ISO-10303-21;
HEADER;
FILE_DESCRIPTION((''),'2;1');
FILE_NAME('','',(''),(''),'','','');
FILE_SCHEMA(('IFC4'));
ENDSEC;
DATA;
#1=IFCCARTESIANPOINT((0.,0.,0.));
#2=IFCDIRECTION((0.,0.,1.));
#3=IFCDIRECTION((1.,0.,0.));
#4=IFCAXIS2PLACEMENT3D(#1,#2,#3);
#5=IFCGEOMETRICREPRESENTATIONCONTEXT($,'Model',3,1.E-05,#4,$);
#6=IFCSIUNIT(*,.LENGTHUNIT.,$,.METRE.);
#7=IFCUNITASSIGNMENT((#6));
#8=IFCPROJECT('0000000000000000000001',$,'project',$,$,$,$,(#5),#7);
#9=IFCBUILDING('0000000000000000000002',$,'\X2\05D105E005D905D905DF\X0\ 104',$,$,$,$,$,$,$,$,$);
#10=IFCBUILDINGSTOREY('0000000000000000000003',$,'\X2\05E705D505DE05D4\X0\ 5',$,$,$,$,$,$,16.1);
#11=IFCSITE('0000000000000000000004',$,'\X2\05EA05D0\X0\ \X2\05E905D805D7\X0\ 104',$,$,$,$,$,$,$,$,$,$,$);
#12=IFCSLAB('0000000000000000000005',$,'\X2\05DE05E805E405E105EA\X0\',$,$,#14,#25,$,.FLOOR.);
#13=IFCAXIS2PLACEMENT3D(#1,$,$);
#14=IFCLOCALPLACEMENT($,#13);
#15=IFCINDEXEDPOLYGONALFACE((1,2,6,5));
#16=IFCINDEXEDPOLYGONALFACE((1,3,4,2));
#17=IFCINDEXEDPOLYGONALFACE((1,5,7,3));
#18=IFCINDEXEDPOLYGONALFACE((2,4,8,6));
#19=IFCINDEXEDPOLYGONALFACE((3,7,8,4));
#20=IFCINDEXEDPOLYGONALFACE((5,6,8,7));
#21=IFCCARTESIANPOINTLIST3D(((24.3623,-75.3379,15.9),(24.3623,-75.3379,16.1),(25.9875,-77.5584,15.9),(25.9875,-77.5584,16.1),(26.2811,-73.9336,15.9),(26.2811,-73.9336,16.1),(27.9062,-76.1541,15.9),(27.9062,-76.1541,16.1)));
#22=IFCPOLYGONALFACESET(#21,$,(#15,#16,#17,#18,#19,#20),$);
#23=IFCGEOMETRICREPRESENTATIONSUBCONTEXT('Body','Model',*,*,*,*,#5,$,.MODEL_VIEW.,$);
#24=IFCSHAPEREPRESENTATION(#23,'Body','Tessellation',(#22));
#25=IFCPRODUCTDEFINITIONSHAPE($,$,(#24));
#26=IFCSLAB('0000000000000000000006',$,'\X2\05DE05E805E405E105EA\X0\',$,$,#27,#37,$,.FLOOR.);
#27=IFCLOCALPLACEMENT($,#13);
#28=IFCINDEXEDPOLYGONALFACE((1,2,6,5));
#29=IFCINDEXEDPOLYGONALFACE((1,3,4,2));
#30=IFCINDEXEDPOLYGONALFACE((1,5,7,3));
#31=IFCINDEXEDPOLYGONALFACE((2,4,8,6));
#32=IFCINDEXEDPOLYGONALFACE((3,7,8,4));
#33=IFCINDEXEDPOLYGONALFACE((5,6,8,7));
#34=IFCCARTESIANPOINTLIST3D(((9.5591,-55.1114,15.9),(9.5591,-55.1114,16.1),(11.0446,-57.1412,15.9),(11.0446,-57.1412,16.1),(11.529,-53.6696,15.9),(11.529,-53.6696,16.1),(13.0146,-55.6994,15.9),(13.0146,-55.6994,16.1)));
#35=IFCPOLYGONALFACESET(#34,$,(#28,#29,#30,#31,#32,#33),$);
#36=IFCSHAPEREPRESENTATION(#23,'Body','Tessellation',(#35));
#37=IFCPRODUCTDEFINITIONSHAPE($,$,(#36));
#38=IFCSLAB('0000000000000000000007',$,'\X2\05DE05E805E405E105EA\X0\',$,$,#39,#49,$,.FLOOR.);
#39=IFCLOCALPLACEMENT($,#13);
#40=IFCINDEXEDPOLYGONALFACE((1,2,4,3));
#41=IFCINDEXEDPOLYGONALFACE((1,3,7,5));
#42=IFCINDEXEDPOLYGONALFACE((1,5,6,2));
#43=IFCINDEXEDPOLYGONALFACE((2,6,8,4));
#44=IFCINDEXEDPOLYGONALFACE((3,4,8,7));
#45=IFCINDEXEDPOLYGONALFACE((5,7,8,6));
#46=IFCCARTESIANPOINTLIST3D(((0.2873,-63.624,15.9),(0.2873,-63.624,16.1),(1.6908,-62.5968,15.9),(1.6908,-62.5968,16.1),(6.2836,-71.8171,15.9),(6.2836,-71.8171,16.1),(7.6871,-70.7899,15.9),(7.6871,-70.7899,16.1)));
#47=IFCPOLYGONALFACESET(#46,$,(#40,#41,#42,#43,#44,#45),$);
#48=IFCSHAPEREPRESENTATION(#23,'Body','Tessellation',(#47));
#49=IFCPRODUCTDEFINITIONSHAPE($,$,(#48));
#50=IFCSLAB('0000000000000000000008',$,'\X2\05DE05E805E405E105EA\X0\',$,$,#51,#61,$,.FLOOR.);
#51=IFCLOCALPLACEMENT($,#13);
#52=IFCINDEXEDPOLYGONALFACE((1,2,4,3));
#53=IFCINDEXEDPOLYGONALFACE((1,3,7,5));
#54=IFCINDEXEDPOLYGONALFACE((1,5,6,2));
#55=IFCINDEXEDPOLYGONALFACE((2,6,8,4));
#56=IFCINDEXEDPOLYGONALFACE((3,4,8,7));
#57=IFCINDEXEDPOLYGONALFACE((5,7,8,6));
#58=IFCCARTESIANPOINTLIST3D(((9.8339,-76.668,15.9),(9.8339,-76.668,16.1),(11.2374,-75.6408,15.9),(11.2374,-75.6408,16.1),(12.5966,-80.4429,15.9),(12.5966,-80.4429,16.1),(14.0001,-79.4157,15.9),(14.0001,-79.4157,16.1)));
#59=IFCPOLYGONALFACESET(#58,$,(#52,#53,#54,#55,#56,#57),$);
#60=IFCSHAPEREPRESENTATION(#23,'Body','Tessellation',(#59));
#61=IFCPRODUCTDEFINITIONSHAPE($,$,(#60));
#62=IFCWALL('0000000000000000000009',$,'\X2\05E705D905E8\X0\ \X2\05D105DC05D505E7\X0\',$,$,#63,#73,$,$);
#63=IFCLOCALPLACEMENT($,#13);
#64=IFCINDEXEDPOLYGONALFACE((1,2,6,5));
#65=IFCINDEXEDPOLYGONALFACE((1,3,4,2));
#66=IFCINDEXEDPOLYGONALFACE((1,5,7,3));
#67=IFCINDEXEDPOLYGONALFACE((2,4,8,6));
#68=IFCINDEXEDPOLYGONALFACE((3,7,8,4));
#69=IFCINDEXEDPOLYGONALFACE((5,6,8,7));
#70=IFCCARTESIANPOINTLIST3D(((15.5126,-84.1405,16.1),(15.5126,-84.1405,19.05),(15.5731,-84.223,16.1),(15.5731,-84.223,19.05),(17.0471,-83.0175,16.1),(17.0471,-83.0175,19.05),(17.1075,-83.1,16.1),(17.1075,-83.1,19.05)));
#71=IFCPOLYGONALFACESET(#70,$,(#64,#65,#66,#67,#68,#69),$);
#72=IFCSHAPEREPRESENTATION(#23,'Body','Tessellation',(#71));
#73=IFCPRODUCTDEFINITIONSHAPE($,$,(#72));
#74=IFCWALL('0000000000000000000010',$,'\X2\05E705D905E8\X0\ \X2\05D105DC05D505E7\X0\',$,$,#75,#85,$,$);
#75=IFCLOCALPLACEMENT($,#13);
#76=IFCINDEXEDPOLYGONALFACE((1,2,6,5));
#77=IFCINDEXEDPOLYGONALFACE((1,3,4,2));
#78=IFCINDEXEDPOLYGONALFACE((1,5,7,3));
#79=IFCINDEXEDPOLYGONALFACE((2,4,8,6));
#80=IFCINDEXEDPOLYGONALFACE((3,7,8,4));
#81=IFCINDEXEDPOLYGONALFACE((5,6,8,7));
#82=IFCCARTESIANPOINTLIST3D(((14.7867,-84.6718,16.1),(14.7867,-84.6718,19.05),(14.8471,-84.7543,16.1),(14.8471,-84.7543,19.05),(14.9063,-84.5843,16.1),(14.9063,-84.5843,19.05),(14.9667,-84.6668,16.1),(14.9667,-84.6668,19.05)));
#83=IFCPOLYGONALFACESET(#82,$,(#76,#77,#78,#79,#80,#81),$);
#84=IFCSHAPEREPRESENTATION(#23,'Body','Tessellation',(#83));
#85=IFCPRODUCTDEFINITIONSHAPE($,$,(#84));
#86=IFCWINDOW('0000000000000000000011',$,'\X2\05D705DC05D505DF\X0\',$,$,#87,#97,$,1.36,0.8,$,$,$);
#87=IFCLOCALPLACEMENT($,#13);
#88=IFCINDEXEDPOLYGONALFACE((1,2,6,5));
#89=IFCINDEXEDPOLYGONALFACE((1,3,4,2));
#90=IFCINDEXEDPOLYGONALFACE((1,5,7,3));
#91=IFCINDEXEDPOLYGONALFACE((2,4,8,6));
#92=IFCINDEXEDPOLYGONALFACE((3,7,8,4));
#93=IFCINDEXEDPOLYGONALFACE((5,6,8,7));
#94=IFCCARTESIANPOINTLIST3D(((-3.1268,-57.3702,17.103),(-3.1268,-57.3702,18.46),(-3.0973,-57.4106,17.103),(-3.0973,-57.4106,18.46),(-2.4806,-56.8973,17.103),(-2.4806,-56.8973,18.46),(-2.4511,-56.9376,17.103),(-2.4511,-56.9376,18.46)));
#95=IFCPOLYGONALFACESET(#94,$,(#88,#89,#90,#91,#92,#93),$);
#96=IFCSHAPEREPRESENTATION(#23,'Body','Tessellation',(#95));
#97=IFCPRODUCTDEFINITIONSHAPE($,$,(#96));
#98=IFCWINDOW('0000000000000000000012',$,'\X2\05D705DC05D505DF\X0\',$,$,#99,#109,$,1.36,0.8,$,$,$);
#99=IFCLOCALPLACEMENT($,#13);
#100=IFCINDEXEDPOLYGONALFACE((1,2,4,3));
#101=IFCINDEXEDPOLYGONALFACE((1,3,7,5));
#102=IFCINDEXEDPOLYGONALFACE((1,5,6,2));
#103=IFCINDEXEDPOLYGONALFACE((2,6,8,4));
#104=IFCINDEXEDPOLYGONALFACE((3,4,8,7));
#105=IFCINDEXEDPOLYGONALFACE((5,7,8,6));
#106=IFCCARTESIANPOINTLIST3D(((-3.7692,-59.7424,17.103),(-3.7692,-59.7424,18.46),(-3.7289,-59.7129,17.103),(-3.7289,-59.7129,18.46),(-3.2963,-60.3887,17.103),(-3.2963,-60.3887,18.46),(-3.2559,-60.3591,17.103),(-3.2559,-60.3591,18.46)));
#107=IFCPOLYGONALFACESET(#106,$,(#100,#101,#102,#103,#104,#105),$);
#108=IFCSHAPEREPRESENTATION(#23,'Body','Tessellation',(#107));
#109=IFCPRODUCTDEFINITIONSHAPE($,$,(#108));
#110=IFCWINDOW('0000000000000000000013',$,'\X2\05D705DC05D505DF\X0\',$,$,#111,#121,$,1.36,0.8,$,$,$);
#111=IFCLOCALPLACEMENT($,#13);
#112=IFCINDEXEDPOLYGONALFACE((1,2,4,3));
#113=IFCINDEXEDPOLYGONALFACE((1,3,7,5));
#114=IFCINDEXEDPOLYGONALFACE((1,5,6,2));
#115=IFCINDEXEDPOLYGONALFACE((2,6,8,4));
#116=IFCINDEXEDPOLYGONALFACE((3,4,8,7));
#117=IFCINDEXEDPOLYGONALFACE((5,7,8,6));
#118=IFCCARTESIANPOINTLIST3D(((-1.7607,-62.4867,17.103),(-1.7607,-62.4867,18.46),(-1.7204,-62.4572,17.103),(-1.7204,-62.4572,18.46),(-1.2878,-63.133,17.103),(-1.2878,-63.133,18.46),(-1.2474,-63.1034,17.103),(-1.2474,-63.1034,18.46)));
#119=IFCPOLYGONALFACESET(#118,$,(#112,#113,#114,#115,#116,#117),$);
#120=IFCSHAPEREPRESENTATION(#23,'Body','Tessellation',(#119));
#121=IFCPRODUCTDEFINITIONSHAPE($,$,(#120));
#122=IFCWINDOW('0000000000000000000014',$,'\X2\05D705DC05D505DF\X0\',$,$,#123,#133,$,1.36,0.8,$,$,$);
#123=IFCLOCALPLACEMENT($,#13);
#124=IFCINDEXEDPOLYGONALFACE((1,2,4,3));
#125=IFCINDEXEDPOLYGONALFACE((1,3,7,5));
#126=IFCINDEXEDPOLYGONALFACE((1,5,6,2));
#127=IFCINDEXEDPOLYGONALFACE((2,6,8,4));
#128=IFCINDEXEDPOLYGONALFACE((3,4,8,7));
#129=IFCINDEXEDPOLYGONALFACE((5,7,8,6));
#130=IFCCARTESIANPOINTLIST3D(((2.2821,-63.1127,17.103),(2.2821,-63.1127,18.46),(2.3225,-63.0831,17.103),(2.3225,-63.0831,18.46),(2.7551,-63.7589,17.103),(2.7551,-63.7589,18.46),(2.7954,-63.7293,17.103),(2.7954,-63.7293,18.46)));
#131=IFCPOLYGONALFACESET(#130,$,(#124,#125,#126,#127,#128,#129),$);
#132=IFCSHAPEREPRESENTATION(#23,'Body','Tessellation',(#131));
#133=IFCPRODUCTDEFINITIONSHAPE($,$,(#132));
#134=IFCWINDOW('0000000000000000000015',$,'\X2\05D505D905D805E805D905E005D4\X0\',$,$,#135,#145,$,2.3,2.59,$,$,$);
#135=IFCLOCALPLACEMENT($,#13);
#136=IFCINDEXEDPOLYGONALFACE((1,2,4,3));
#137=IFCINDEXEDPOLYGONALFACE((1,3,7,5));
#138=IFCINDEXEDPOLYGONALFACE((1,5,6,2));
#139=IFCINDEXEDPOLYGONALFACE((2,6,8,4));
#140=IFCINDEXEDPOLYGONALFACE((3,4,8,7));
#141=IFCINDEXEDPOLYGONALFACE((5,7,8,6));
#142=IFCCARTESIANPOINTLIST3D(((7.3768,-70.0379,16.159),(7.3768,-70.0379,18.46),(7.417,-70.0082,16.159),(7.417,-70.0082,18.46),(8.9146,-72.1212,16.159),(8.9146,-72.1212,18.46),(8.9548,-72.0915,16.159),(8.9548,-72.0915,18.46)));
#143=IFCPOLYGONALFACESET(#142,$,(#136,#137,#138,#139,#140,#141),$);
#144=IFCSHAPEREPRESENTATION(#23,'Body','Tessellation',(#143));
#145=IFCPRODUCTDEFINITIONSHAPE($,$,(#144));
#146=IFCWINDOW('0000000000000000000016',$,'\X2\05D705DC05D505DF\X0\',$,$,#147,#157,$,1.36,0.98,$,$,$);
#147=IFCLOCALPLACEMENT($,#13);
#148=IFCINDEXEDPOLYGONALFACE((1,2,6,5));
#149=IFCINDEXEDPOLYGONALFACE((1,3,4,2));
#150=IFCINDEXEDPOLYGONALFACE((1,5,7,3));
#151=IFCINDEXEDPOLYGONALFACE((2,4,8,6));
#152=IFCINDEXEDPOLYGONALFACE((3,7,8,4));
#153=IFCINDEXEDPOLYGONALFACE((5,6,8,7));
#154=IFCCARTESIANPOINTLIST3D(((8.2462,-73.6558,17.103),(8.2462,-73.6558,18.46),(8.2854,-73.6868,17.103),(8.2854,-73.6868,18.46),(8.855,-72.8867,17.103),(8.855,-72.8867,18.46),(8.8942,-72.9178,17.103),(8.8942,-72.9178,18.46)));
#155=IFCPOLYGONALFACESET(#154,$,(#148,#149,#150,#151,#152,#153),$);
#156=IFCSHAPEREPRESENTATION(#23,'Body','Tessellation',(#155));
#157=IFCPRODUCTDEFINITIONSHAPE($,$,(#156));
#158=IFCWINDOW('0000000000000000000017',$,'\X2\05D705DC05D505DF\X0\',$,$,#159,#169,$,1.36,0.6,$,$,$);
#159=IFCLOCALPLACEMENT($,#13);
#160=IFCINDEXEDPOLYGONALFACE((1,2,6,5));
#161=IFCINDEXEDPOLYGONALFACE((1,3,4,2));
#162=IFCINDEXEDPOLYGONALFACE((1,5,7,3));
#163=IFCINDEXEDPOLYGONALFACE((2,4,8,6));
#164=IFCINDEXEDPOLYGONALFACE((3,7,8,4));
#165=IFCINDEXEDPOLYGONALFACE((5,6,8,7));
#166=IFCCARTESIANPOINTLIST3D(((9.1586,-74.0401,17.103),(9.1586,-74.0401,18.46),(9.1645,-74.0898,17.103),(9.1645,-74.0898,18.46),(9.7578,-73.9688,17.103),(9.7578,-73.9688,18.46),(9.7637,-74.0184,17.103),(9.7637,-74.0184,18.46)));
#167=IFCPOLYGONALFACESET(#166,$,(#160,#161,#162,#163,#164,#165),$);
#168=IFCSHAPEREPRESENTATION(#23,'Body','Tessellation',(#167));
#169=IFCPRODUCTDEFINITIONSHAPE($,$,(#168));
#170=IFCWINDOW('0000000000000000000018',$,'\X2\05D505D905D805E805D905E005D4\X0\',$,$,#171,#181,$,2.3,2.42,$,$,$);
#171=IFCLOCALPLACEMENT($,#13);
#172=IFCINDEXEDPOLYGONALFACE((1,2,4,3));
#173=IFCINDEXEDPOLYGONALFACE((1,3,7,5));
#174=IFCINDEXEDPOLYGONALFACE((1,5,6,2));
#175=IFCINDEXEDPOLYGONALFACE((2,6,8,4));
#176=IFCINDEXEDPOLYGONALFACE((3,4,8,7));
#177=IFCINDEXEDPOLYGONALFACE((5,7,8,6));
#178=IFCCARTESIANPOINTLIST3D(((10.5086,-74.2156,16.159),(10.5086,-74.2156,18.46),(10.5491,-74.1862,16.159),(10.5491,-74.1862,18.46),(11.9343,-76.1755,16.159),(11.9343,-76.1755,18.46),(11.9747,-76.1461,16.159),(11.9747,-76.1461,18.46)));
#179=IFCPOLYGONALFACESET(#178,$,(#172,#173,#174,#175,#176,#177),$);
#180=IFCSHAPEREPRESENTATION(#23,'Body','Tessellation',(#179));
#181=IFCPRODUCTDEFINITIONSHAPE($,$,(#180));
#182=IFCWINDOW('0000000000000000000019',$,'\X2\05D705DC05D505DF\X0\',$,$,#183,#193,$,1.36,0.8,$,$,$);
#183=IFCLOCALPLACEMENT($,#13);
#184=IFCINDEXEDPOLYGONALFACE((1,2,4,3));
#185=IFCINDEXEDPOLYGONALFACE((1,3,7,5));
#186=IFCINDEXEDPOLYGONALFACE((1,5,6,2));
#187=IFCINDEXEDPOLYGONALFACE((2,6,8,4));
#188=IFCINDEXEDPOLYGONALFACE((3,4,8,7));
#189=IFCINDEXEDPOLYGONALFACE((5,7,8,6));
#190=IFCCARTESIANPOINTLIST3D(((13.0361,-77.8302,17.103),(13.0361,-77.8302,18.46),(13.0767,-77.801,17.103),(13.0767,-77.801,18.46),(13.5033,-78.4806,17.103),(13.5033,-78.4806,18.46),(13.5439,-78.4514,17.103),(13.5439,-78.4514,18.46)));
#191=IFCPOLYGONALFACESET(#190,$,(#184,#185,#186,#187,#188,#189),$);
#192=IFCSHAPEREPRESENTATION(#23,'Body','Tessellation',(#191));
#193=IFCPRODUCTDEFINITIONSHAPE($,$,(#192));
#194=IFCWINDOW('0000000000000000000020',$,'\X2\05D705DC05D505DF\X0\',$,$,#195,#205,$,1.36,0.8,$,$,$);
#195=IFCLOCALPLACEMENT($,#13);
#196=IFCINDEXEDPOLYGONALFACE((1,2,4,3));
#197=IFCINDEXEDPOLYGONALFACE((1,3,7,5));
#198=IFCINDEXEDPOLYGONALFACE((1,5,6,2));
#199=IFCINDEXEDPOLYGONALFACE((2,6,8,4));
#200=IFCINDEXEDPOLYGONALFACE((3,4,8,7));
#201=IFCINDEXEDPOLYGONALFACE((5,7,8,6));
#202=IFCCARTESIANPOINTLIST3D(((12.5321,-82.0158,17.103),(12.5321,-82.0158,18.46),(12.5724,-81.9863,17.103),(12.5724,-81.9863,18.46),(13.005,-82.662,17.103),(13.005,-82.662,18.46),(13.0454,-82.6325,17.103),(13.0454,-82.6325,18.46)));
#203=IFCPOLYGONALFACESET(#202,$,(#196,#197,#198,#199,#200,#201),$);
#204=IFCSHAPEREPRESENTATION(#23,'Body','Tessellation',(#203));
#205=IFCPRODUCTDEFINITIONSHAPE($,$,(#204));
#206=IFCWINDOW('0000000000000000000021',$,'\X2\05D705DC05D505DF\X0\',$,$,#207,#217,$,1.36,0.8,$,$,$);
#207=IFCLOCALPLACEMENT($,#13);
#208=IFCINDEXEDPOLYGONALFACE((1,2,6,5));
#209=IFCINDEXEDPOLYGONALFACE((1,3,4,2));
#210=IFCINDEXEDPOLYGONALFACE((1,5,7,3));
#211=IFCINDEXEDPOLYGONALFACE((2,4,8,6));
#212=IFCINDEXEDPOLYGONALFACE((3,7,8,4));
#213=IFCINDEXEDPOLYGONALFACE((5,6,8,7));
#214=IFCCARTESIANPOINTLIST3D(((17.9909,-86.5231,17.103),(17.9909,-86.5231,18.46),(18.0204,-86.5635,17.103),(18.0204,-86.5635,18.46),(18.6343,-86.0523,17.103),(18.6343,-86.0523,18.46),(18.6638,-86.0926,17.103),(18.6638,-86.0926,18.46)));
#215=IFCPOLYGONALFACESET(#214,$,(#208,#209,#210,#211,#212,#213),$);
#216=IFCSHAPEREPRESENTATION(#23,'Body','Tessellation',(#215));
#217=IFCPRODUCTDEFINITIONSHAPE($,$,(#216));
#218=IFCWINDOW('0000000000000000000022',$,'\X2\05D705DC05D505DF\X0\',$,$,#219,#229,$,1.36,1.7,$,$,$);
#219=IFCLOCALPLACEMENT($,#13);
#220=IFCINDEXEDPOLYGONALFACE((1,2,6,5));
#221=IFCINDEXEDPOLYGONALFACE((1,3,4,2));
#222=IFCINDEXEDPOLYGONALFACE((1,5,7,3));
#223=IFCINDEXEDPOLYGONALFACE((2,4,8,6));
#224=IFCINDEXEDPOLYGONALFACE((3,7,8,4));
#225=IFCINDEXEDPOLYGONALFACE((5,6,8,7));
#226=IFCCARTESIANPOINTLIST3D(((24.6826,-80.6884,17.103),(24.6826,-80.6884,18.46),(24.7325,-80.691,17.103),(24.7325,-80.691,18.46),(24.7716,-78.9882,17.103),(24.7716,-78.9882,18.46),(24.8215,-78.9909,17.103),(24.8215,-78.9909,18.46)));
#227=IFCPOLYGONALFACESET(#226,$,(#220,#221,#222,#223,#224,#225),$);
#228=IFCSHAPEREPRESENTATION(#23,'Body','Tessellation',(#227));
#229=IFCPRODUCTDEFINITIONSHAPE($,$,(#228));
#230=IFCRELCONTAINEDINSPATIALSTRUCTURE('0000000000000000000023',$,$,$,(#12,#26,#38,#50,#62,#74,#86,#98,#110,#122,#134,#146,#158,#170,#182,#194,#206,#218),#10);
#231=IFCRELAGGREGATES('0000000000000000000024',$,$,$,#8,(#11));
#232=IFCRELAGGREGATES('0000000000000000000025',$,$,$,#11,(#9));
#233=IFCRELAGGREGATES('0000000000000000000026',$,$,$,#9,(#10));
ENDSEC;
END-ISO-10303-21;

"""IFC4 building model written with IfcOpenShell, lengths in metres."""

from ifc_helpers import new_model, si_unit, frame, origin_with_axes, context, subcontext, project, spatial, polyline, outline, extrude, element, save


model = new_model("IFC4")

# Units and contexts
model_context = context("Model", 3, precision=1e-05, world=origin_with_axes())
body_context = subcontext(model_context, "Body", "Model", "MODEL_VIEW")
ifc_project = project(units=[si_unit("LENGTHUNIT", "METRE")], contexts=[model_context])

# Site, building, storey
site = spatial("IfcSite", under=ifc_project, Name="תא שטח 104")
building = spatial("IfcBuilding", under=site, Name="בניין 104")
storey = spatial("IfcBuildingStorey", under=building, Name="קומה 5", Elevation=16.1)

# Slabs
element("IfcSlab", 1, inside=storey, Name="מרפסת", PredefinedType="FLOOR", context=body_context, shape_type="SweptSolid", body=[
    extrude(outline(polyline([(26.2811, -73.9336), (27.9062, -76.1541), (25.9875, -77.5584), (24.3623, -75.3379), (26.2811, -73.9336)])), frame((0.0, 0.0, 15.9)), (0.0, 0.0, 1.0), 0.2),
])
element("IfcSlab", 2, inside=storey, Name="מרפסת", PredefinedType="FLOOR", context=body_context, shape_type="SweptSolid", body=[
    extrude(outline(polyline([(11.529, -53.6696), (13.0146, -55.6994), (11.0446, -57.1412), (9.5591, -55.1114), (11.529, -53.6696)])), frame((0.0, 0.0, 15.9)), (0.0, 0.0, 1.0), 0.2),
])
element("IfcSlab", 3, inside=storey, Name="מרפסת", PredefinedType="FLOOR", context=body_context, shape_type="SweptSolid", body=[
    extrude(outline(polyline([(1.6908, -62.5968), (7.6871, -70.7899), (6.2836, -71.8171), (0.2873, -63.624), (1.6908, -62.5968)])), frame((0.0, 0.0, 15.9)), (0.0, 0.0, 1.0), 0.2),
])
element("IfcSlab", 4, inside=storey, Name="מרפסת", PredefinedType="FLOOR", context=body_context, shape_type="SweptSolid", body=[
    extrude(outline(polyline([(11.2374, -75.6408), (14.0001, -79.4157), (12.5966, -80.4429), (9.8339, -76.668), (11.2374, -75.6408)])), frame((0.0, 0.0, 15.9)), (0.0, 0.0, 1.0), 0.2),
])

# Walls
element("IfcWall", 5, inside=storey, Name="קיר בלוק", context=body_context, shape_type="SweptSolid", body=[
    extrude(outline(polyline([(17.1075, -83.1), (17.0471, -83.0175), (15.5126, -84.1405), (15.5731, -84.223), (17.1075, -83.1)])), frame((0.0, 0.0, 16.1)), (0.0, 0.0, 1.0), 2.95),
])
element("IfcWall", 6, inside=storey, Name="קיר בלוק", context=body_context, shape_type="SweptSolid", body=[
    extrude(outline(polyline([(14.7867, -84.6718), (14.8471, -84.7543), (14.9667, -84.6668), (14.9063, -84.5843), (14.7867, -84.6718)])), frame((0.0, 0.0, 16.1)), (0.0, 0.0, 1.0), 2.95),
])

# Windows
element("IfcWindow", 7, inside=storey, Name="חלון", OverallHeight=1.36, OverallWidth=0.8, context=body_context, shape_type="SweptSolid", body=[
    extrude(outline(polyline([(-2.4806, -56.8973), (-3.1268, -57.3702), (-3.0973, -57.4106), (-2.4511, -56.9376), (-2.4806, -56.8973)])), frame((0.0, 0.0, 17.103)), (0.0, 0.0, 1.0), 1.357),
])
element("IfcWindow", 8, inside=storey, Name="חלון", OverallHeight=1.36, OverallWidth=0.8, context=body_context, shape_type="SweptSolid", body=[
    extrude(outline(polyline([(-3.7692, -59.7424), (-3.2963, -60.3887), (-3.2559, -60.3591), (-3.7289, -59.7129), (-3.7692, -59.7424)])), frame((0.0, 0.0, 17.103)), (0.0, 0.0, 1.0), 1.357),
])
element("IfcWindow", 9, inside=storey, Name="חלון", OverallHeight=1.36, OverallWidth=0.8, context=body_context, shape_type="SweptSolid", body=[
    extrude(outline(polyline([(-1.7607, -62.4867), (-1.2878, -63.133), (-1.2474, -63.1034), (-1.7204, -62.4572), (-1.7607, -62.4867)])), frame((0.0, 0.0, 17.103)), (0.0, 0.0, 1.0), 1.357),
])
element("IfcWindow", 10, inside=storey, Name="חלון", OverallHeight=1.36, OverallWidth=0.8, context=body_context, shape_type="SweptSolid", body=[
    extrude(outline(polyline([(2.2821, -63.1127), (2.7551, -63.7589), (2.7954, -63.7293), (2.3225, -63.0831), (2.2821, -63.1127)])), frame((0.0, 0.0, 17.103)), (0.0, 0.0, 1.0), 1.357),
])
element("IfcWindow", 11, inside=storey, Name="ויטרינה", OverallHeight=2.3, OverallWidth=2.59, context=body_context, shape_type="SweptSolid", body=[
    extrude(outline(polyline([(7.3768, -70.0379), (8.9146, -72.1212), (8.9548, -72.0915), (7.417, -70.0082), (7.3768, -70.0379)])), frame((0.0, 0.0, 16.159)), (0.0, 0.0, 1.0), 2.301),
])
element("IfcWindow", 12, inside=storey, Name="חלון", OverallHeight=1.36, OverallWidth=0.98, context=body_context, shape_type="SweptSolid", body=[
    extrude(outline(polyline([(8.855, -72.8867), (8.2462, -73.6558), (8.2854, -73.6868), (8.8942, -72.9178), (8.855, -72.8867)])), frame((0.0, 0.0, 17.103)), (0.0, 0.0, 1.0), 1.357),
])
element("IfcWindow", 13, inside=storey, Name="חלון", OverallHeight=1.36, OverallWidth=0.6, context=body_context, shape_type="SweptSolid", body=[
    extrude(outline(polyline([(9.1645, -74.0898), (9.7637, -74.0184), (9.7578, -73.9688), (9.1586, -74.0401), (9.1645, -74.0898)])), frame((0.0, 0.0, 17.103)), (0.0, 0.0, 1.0), 1.357),
])
element("IfcWindow", 14, inside=storey, Name="ויטרינה", OverallHeight=2.3, OverallWidth=2.42, context=body_context, shape_type="SweptSolid", body=[
    extrude(outline(polyline([(10.5086, -74.2156), (11.9343, -76.1755), (11.9747, -76.1461), (10.5491, -74.1862), (10.5086, -74.2156)])), frame((0.0, 0.0, 16.159)), (0.0, 0.0, 1.0), 2.301),
])
element("IfcWindow", 15, inside=storey, Name="חלון", OverallHeight=1.36, OverallWidth=0.8, context=body_context, shape_type="SweptSolid", body=[
    extrude(outline(polyline([(13.0361, -77.8302), (13.5033, -78.4806), (13.5439, -78.4514), (13.0767, -77.801), (13.0361, -77.8302)])), frame((0.0, 0.0, 17.103)), (0.0, 0.0, 1.0), 1.357),
])
element("IfcWindow", 16, inside=storey, Name="חלון", OverallHeight=1.36, OverallWidth=0.8, context=body_context, shape_type="SweptSolid", body=[
    extrude(outline(polyline([(12.5321, -82.0158), (13.005, -82.662), (13.0454, -82.6325), (12.5724, -81.9863), (12.5321, -82.0158)])), frame((0.0, 0.0, 17.103)), (0.0, 0.0, 1.0), 1.357),
])
element("IfcWindow", 17, inside=storey, Name="חלון", OverallHeight=1.36, OverallWidth=0.8, context=body_context, shape_type="SweptSolid", body=[
    extrude(outline(polyline([(18.0204, -86.5635), (18.6638, -86.0926), (18.6343, -86.0523), (17.9909, -86.5231), (18.0204, -86.5635)])), frame((0.0, 0.0, 17.103)), (0.0, 0.0, 1.0), 1.357),
])
element("IfcWindow", 18, inside=storey, Name="חלון", OverallHeight=1.36, OverallWidth=1.7, context=body_context, shape_type="SweptSolid", body=[
    extrude(outline(polyline([(24.7325, -80.691), (24.8215, -78.9909), (24.7716, -78.9882), (24.6826, -80.6884), (24.7325, -80.691)])), frame((0.0, 0.0, 17.103)), (0.0, 0.0, 1.0), 1.357),
])

save(model, "model.ifc")
